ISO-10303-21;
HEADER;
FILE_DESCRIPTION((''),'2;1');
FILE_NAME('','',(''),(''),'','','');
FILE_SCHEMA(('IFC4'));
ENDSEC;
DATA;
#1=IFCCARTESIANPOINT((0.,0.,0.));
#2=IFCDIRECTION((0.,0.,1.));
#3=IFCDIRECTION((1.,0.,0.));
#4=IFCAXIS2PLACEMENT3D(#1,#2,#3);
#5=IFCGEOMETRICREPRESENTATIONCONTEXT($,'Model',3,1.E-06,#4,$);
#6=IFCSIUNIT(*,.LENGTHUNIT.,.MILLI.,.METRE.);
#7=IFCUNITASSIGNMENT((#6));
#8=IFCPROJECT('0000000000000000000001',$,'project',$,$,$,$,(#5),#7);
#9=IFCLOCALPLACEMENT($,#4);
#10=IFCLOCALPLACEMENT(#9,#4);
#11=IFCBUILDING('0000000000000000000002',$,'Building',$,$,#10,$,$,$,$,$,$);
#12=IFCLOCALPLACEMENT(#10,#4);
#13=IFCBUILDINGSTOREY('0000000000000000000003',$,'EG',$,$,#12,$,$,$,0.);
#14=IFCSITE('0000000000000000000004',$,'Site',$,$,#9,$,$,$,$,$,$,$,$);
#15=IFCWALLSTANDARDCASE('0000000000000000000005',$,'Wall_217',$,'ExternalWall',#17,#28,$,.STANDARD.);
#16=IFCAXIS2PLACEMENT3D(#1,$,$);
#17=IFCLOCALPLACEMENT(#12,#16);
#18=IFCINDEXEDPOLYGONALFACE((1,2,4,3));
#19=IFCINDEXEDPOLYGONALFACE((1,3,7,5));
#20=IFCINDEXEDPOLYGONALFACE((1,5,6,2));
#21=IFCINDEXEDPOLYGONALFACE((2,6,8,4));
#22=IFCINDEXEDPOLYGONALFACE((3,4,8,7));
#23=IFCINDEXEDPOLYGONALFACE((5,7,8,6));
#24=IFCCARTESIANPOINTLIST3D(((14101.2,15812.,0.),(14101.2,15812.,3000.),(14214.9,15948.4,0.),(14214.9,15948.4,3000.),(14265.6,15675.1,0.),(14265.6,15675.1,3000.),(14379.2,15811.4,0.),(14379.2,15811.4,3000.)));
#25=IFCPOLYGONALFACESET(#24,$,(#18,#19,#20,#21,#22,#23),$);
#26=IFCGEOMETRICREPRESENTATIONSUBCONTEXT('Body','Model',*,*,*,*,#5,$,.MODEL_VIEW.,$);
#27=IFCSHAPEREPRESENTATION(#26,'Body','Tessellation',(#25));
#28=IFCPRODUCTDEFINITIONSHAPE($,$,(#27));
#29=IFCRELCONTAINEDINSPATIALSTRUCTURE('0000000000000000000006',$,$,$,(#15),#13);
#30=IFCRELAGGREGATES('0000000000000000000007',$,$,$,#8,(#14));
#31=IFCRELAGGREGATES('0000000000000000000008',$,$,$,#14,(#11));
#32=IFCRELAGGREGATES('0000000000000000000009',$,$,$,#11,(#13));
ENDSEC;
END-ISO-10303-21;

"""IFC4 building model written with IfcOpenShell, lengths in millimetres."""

from ifc_helpers import new_model, si_unit, frame, origin_with_axes, place, context, subcontext, project, spatial, rectangle, extrude, element, save


model = new_model("IFC4")

# Units and contexts
model_context = context("Model", 3, precision=1e-06, world=origin_with_axes())
body_context = subcontext(model_context, "Body", "Model", "MODEL_VIEW")
ifc_project = project(units=[si_unit("LENGTHUNIT", "METRE", prefix="MILLI")], contexts=[model_context])

# Site, building, storey
site_placement = place(None, origin_with_axes())
site = spatial("IfcSite", under=ifc_project, at=site_placement, Name="Site")
building_placement = place(site_placement, origin_with_axes())
building = spatial("IfcBuilding", under=site, at=building_placement, Name="Building")
storey_placement = place(building_placement, origin_with_axes())
storey = spatial("IfcBuildingStorey", under=building, at=storey_placement, Name="EG", Elevation=0.0)

# Wall
wall_1_placement = place(storey_placement, origin_with_axes())
element("IfcWallStandardCase", 1, at=wall_1_placement, inside=storey, Name="Wall_217", ObjectType="ExternalWall", PredefinedType="STANDARD", context=body_context, shape_type="SweptSolid", body=[
    extrude(rectangle(XDim=214.0, YDim=177.5), frame((14240.2, 15811.7, 0.0), z_axis=(0.0, 0.0, 1.0), x_axis=(-0.768221, 0.640184, 0.0)), (0.0, 0.0, 1.0), 3000.0),
])

save(model, "model.ifc")
